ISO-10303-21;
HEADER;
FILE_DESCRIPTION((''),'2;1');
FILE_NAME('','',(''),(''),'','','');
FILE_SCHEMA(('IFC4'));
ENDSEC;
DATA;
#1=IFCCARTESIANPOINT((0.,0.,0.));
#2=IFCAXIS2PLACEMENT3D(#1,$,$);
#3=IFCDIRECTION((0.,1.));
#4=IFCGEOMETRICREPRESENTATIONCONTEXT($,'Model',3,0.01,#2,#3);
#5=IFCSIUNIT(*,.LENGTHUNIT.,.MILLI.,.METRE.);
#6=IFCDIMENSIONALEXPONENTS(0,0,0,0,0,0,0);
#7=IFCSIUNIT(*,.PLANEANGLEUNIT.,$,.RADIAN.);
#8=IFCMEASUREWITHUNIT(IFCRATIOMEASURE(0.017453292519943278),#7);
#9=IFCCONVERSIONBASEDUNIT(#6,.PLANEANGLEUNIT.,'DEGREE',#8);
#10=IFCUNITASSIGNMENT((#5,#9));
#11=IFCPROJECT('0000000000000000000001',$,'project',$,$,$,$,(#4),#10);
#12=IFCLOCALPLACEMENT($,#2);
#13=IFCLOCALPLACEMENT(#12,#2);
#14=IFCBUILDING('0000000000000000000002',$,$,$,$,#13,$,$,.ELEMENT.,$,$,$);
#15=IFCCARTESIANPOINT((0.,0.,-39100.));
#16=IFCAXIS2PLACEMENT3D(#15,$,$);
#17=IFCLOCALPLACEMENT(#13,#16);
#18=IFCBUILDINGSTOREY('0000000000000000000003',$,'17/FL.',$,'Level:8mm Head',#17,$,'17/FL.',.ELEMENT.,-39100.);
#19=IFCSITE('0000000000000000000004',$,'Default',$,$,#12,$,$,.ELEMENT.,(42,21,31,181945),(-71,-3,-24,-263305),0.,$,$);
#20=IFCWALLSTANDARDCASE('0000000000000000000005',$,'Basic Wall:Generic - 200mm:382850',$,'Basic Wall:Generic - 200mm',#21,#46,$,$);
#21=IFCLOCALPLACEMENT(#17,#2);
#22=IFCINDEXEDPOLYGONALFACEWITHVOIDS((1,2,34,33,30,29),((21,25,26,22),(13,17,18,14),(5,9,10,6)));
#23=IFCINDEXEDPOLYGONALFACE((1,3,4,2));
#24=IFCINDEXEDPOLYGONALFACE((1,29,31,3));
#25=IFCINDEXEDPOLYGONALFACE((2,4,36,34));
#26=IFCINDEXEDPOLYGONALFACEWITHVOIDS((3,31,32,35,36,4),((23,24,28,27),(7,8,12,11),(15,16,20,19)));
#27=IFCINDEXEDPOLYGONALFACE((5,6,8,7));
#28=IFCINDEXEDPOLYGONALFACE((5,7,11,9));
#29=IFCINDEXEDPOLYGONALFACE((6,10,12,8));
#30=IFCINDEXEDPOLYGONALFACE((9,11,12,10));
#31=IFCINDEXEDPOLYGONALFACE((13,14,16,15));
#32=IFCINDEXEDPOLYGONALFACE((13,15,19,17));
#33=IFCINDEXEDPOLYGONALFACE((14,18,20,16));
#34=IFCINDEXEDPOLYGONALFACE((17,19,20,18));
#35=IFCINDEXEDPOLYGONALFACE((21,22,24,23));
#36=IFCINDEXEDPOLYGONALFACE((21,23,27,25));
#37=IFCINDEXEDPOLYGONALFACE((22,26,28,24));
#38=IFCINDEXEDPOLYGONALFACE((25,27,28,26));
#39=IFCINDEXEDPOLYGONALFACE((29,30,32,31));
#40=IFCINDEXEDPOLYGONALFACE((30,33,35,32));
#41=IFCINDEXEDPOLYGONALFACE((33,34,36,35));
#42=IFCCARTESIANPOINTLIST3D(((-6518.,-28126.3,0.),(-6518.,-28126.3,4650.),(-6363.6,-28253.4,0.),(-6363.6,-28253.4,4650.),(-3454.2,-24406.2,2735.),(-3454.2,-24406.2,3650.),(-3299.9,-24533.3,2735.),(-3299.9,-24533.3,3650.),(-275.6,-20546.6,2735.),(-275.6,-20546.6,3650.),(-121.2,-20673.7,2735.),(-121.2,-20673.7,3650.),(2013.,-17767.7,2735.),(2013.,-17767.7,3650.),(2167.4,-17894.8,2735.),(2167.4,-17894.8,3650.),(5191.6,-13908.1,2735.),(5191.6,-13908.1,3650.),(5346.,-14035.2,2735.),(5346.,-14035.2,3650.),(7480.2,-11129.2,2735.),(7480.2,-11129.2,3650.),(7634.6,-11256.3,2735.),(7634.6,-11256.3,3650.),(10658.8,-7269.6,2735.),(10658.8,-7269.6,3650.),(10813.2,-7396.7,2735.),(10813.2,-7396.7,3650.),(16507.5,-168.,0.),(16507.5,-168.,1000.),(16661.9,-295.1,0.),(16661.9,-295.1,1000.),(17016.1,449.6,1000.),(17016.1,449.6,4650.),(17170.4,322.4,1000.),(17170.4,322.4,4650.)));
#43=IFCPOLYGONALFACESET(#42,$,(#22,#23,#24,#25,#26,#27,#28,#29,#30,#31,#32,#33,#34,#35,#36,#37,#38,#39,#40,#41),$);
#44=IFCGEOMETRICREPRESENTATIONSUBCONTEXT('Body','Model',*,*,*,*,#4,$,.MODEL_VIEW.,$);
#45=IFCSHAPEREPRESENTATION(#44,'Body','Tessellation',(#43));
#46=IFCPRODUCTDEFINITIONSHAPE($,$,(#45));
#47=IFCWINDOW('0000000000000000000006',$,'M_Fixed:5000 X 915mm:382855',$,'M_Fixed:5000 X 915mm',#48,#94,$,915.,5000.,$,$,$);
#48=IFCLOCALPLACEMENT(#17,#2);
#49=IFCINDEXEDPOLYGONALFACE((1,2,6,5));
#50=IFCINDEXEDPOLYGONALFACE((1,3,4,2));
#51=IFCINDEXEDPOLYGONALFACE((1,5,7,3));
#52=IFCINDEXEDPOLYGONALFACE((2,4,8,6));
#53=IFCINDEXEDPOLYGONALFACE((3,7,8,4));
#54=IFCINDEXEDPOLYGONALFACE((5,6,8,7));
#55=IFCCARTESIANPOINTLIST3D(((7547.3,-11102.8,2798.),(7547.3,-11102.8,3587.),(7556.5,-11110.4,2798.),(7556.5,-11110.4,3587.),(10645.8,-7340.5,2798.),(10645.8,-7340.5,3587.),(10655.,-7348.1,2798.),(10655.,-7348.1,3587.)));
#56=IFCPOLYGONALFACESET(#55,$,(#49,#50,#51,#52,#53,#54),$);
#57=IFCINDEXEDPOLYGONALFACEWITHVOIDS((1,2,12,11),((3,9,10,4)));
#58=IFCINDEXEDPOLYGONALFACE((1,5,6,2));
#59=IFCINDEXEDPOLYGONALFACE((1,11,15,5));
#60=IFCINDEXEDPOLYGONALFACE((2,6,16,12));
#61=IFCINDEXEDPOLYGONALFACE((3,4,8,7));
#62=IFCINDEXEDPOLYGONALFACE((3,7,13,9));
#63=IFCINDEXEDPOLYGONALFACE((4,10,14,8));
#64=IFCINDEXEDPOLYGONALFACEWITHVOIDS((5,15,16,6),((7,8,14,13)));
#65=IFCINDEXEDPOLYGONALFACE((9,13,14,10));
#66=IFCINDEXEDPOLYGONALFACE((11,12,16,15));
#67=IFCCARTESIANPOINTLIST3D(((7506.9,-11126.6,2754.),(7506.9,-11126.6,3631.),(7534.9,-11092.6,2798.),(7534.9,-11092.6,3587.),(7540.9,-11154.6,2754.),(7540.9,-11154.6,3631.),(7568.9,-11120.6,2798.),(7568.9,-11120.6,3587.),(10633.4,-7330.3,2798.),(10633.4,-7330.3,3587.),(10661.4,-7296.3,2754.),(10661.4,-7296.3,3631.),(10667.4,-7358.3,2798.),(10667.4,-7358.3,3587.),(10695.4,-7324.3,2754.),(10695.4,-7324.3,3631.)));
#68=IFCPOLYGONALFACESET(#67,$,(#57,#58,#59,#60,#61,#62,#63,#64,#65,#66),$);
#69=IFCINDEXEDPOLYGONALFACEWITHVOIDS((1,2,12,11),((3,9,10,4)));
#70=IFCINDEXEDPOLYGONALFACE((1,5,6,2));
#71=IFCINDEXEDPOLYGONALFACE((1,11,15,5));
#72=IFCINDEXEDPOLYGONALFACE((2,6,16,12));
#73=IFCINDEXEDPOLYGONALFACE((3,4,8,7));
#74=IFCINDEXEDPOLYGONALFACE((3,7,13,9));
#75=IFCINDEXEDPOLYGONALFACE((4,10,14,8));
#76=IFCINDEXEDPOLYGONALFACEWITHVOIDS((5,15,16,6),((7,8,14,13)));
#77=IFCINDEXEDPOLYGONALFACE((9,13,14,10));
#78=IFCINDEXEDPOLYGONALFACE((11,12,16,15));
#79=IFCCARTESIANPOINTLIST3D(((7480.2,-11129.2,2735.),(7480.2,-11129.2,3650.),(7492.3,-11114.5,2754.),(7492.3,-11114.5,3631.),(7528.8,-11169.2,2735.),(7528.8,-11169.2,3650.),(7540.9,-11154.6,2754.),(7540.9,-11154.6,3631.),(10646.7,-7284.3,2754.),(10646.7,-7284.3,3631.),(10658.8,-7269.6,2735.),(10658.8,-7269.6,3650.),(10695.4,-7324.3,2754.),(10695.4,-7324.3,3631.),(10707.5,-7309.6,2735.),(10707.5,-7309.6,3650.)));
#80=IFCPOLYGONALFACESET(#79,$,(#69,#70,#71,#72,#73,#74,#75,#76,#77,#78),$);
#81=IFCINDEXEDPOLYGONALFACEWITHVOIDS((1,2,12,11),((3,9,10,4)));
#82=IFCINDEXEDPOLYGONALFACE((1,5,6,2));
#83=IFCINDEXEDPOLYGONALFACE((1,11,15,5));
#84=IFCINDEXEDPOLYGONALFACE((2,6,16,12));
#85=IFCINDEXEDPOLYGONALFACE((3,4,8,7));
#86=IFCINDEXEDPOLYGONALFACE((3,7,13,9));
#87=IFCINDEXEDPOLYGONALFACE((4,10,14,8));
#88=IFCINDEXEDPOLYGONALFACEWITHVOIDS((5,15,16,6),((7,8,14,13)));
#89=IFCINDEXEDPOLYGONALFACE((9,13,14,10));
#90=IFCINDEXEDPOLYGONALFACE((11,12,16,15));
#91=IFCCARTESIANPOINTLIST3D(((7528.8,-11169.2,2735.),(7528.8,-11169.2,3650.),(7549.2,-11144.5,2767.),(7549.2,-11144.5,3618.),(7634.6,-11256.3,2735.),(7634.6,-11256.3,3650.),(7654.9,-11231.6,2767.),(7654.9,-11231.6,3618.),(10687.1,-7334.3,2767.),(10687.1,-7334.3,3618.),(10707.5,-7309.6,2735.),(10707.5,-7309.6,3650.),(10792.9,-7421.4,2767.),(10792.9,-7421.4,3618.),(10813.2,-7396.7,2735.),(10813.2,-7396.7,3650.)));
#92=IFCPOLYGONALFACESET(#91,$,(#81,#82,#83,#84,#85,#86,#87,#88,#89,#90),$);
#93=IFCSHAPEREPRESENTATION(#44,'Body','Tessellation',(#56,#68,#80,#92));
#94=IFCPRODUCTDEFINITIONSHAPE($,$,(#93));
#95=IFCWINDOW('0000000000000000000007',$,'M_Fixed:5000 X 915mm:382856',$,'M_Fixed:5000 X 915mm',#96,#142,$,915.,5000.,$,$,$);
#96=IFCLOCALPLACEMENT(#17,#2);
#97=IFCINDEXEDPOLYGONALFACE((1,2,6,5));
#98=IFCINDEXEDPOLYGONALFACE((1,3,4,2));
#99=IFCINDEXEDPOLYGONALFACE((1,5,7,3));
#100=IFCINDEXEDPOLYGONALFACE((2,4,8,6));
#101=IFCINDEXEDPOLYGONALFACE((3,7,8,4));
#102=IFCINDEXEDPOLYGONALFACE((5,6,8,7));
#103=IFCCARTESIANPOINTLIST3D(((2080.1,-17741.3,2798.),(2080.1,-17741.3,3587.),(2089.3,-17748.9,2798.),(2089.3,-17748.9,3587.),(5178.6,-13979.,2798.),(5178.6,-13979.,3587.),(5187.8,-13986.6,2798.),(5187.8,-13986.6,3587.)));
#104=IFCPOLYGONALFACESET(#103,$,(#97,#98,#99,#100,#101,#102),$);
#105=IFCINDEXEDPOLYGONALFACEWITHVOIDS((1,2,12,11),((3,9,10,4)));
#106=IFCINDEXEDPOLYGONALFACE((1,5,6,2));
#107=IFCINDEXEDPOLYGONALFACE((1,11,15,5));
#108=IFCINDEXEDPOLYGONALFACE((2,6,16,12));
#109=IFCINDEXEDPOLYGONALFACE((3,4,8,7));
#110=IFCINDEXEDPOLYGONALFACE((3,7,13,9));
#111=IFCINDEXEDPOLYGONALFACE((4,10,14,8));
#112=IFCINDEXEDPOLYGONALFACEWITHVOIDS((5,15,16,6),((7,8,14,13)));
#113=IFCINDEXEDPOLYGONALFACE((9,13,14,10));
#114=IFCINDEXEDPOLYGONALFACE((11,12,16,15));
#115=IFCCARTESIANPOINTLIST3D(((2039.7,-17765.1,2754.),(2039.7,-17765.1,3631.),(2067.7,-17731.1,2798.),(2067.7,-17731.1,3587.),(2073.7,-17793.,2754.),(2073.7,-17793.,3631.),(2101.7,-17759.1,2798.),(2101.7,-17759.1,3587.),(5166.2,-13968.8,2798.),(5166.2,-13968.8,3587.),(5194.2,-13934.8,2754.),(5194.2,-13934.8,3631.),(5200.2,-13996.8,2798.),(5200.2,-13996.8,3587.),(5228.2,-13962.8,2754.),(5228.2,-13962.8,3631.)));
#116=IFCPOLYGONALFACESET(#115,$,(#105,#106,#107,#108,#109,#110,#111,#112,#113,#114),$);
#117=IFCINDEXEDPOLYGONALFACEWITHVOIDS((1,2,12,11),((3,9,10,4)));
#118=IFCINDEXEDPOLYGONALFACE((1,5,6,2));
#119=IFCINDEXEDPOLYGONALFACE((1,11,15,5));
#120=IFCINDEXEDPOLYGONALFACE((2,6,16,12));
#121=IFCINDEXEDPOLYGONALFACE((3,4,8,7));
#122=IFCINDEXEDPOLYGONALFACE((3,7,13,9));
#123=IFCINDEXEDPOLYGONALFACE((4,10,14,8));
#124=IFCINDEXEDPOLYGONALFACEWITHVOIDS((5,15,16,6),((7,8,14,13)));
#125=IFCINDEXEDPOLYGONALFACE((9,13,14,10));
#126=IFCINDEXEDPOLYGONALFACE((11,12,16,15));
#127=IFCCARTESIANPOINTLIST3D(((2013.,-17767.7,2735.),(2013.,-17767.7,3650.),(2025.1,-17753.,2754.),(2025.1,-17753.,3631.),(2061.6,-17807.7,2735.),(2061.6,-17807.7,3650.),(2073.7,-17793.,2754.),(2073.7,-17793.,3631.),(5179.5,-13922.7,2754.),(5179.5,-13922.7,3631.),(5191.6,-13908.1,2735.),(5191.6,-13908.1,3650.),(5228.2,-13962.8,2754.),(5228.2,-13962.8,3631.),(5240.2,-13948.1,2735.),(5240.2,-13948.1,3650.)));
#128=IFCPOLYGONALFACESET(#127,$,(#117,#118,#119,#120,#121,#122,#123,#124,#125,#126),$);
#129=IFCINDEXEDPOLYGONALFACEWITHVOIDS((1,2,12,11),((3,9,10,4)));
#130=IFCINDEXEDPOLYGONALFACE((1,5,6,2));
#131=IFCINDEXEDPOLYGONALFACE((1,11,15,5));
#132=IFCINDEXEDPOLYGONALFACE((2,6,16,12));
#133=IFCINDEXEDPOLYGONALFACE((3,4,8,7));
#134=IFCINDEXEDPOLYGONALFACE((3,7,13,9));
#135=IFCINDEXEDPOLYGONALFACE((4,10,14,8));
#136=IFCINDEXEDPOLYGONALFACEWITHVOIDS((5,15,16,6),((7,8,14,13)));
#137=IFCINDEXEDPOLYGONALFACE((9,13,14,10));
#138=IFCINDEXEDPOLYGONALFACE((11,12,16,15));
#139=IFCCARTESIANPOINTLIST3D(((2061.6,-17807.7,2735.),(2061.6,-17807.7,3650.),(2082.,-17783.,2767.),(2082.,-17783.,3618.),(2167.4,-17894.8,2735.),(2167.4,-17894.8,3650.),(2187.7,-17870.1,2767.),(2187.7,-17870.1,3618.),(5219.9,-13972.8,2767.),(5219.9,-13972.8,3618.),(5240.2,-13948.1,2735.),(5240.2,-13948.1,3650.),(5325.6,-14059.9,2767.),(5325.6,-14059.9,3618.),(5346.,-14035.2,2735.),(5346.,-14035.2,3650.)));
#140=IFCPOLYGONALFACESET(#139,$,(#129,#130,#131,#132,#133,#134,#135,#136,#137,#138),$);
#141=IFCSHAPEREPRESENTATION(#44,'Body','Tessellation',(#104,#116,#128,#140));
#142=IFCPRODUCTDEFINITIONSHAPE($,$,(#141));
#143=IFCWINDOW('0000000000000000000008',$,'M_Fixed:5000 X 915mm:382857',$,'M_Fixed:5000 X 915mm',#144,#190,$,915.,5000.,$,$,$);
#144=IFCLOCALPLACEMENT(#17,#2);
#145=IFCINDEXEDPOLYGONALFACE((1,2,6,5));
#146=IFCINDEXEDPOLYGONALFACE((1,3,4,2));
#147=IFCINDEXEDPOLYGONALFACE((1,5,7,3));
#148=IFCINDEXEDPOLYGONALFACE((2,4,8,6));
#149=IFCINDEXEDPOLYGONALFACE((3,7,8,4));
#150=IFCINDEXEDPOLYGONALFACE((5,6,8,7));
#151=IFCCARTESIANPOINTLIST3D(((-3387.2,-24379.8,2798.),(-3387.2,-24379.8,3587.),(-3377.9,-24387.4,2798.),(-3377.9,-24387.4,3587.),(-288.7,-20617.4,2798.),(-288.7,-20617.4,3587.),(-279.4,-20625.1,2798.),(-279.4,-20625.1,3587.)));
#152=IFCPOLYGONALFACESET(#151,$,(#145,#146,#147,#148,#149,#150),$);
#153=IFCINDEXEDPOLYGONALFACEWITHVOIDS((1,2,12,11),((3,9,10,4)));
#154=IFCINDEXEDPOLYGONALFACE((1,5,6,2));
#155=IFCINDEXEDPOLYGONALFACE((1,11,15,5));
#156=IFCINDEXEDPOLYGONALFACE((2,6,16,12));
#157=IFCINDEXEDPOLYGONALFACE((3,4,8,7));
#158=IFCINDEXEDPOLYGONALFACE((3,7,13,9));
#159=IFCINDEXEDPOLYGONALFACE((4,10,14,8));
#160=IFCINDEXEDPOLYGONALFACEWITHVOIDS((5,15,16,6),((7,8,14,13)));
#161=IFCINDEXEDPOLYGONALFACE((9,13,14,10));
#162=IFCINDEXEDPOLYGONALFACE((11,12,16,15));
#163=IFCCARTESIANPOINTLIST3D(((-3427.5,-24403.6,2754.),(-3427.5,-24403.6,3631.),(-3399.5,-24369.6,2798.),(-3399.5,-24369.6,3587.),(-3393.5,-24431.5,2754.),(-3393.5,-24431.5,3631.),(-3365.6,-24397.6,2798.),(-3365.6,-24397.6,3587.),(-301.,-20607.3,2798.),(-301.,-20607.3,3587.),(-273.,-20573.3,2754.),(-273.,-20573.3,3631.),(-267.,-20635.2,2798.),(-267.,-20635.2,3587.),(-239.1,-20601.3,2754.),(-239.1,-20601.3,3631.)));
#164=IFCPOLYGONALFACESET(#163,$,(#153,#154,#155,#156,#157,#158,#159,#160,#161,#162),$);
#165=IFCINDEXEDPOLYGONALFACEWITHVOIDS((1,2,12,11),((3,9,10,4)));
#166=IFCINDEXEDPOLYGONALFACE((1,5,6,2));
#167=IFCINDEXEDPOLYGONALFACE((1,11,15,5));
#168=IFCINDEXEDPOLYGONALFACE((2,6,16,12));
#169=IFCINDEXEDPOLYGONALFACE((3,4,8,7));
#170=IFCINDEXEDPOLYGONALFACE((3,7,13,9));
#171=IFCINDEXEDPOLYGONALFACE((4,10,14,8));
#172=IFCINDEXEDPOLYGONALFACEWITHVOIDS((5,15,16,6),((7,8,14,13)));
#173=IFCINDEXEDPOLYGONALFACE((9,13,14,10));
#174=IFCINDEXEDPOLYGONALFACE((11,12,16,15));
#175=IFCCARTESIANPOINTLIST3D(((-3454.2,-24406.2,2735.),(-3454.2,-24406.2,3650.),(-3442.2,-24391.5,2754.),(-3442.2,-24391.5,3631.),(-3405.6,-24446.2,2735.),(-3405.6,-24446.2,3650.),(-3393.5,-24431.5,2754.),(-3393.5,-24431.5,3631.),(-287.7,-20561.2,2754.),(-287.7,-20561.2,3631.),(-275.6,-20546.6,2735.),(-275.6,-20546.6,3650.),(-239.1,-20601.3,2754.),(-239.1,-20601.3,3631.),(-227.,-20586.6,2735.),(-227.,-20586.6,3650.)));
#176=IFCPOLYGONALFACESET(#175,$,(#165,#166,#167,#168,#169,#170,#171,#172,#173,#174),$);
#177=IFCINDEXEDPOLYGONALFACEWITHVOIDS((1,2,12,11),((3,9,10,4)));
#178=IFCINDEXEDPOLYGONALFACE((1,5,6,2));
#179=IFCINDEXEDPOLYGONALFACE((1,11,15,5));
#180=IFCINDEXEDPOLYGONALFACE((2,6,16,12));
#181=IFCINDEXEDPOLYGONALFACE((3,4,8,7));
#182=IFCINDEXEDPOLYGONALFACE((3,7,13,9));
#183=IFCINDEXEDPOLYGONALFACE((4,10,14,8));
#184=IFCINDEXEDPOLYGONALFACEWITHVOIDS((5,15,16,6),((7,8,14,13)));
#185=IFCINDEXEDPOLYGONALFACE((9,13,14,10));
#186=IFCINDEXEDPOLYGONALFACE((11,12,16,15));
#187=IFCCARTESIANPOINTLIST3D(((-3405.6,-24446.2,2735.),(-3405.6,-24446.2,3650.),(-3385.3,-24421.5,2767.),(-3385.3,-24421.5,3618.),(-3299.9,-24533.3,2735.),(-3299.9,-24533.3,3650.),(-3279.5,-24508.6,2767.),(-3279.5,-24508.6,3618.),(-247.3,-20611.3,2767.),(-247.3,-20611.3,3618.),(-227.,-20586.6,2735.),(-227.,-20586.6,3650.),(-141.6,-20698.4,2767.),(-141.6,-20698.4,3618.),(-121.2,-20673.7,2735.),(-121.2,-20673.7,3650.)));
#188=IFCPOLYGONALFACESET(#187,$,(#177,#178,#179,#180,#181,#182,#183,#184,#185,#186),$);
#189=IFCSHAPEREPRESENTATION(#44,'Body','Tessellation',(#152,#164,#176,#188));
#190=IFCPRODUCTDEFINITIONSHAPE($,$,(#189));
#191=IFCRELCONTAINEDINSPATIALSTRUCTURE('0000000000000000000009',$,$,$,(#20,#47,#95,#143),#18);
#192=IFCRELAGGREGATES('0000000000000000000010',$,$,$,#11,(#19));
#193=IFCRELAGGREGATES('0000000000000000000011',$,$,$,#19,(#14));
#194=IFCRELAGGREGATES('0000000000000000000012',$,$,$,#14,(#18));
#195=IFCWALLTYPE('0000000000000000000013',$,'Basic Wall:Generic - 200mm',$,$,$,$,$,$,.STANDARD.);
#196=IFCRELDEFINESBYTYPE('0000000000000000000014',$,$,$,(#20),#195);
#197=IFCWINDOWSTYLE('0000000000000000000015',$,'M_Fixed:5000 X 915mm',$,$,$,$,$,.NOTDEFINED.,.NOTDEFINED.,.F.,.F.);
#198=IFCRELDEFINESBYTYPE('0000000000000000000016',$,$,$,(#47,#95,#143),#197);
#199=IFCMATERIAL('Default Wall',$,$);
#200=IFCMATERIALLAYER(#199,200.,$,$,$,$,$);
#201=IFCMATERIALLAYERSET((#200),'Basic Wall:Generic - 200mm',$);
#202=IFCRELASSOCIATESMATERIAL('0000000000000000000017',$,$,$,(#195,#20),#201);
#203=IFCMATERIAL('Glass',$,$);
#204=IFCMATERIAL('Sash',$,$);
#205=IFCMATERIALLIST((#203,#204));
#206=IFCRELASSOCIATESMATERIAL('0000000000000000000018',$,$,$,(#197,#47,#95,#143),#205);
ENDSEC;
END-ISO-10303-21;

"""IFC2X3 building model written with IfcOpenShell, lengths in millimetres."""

from ifc_helpers import new_model, entity, si_unit, converted_unit, direction, frame, frame_2d, origin, place, context, subcontext, project, spatial, polyline, rectangle, outline, extrude, source, transform, mapped, material, material_list, layer, layer_set, layer_usage, type_object, type_shapes, element, fill, save


model = new_model("IFC2X3")

# Units and contexts
model_context = context("Model", 3, precision=0.01, world=origin(), true_north=direction((0.0, 1.0)))
body_context = subcontext(model_context, "Body", "Model", "MODEL_VIEW")
ifc_project = project(units=[si_unit("LENGTHUNIT", "METRE", prefix="MILLI"), converted_unit("PLANEANGLEUNIT", "DEGREE", entity("IfcRatioMeasure", 0.017453292519943278), si_unit("PLANEANGLEUNIT", "RADIAN"), dimensions=[0, 0, 0, 0, 0, 0, 0])], contexts=[model_context])

# Site, building, storey
site_placement = place(None, origin())
site = spatial("IfcSite", under=ifc_project, at=site_placement, Name="Default", CompositionType="ELEMENT", RefLatitude=(42, 21, 31, 181945), RefLongitude=(-71, -3, -24, -263305), RefElevation=0.0)
building_placement = place(site_placement, origin())
building = spatial("IfcBuilding", under=site, at=building_placement, CompositionType="ELEMENT")
storey_placement = place(building_placement, frame((0.0, 0.0, -39100.0)))
storey = spatial("IfcBuildingStorey", under=building, at=storey_placement, Name="17/FL.", ObjectType="Level:8mm Head", LongName="17/FL.", CompositionType="ELEMENT", Elevation=-39100.0)

# Shared definitions
ifc_material_1 = material(Name="Default Wall")
ifc_layer = layer(ifc_material_1, 200.0)
ifc_layer_set = layer_set([ifc_layer], Name="Basic Wall:Generic - 200mm")
ifc_layer_usage = layer_usage(ifc_layer_set, "AXIS2", "NEGATIVE", 100.0)
wall_type = type_object("IfcWallType", Name="Basic Wall:Generic - 200mm", PredefinedType="STANDARD", material=ifc_layer_set)

# Wall, openings, windows
wall_1_placement = place(storey_placement, frame((17093.2, 386.0, 0.0), z_axis=(0.0, 0.0, 1.0), x_axis=(-0.635723, -0.771917, 0.0)))
wall_1 = element("IfcWallStandardCase", 1, at=wall_1_placement, inside=storey, type_object=wall_type, material=ifc_layer_usage, Name="Basic Wall:Generic - 200mm:382850", ObjectType="Basic Wall:Generic - 200mm", context=body_context, shape_type="SweptSolid", body=[
    extrude(rectangle(XDim=37019.3, YDim=200.0, at=frame_2d((18509.7, 0.0), x_axis=(-1.0, 0.0))), origin(), (0.0, 0.0, 1.0), 4650.0),
])
opening_1_placement = place(wall_1_placement, origin())
element("IfcOpeningElement", 2, at=opening_1_placement, cuts=wall_1, ObjectType="Opening", context=body_context, shape_type="SweptSolid", body=[
    extrude(rectangle(XDim=1000.0, YDim=1012.7, at=frame_2d((0.0, 0.0), x_axis=(1.0, 0.0))), frame((293.7, -183.3, 500.0), z_axis=(0.0, 1.0, 0.0), x_axis=(0.0, 0.0, -1.0)), (0.0, 0.0, 1.0), 1010.1),
])
opening_2_placement = place(wall_1_placement, frame((15000.0, 100.0, 2735.0)))
opening_2 = element("IfcOpeningElement", 3, at=opening_2_placement, cuts=wall_1, ObjectType="Opening", context=body_context, shape_type="SweptSolid", body=[
    extrude(rectangle(XDim=915.0, YDim=5000.0, at=frame_2d((457.5, 2500.0), x_axis=(1.0, 0.0))), frame((0.0, 0.0, 0.0), z_axis=(0.0, -1.0, 0.0), x_axis=(0.0, 0.0, 1.0)), (0.0, 0.0, 1.0), 200.0),
])
opening_3_placement = place(wall_1_placement, frame((23600.0, 100.0, 2735.0)))
opening_3 = element("IfcOpeningElement", 4, at=opening_3_placement, cuts=wall_1, ObjectType="Opening", context=body_context, shape_type="SweptSolid", body=[
    extrude(rectangle(XDim=915.0, YDim=5000.0, at=frame_2d((457.5, 2500.0), x_axis=(1.0, 0.0))), frame((0.0, 0.0, 0.0), z_axis=(0.0, -1.0, 0.0), x_axis=(0.0, 0.0, 1.0)), (0.0, 0.0, 1.0), 200.0),
])
opening_4_placement = place(wall_1_placement, frame((32200.0, 100.0, 2735.0)))
opening_4 = element("IfcOpeningElement", 5, at=opening_4_placement, cuts=wall_1, ObjectType="Opening", context=body_context, shape_type="SweptSolid", body=[
    extrude(rectangle(XDim=915.0, YDim=5000.0, at=frame_2d((457.5, 2500.0), x_axis=(1.0, 0.0))), frame((0.0, 0.0, 0.0), z_axis=(0.0, -1.0, 0.0), x_axis=(0.0, 0.0, 1.0)), (0.0, 0.0, 1.0), 200.0),
])
ifc_material_2 = material(Name="Glass")
ifc_material_3 = material(Name="Sash")
ifc_material_list = material_list([ifc_material_2, ifc_material_3])
window_style_1 = type_object("IfcWindowStyle", Name="M_Fixed:5000 X 915mm", ConstructionType="NOTDEFINED", OperationType="NOTDEFINED", ParameterTakesPrecedence=False, Sizeable=False, material=ifc_material_list)
shared_shape_1 = source(origin(), body_context, "Body", "SweptSolid", [
    extrude(rectangle(XDim=12.0, YDim=4874.0, at=frame_2d((0.0, 0.0), x_axis=(1.0, 0.0))), frame((2500.0, 159.0, 63.0), z_axis=(0.0, 0.0, 1.0), x_axis=(0.0, -1.0, 0.0)), (0.0, 0.0, 1.0), 789.0),
    extrude(outline(polyline([(-2481.0, -438.5), (2481.0, -438.5), (2481.0, 438.5), (-2481.0, 438.5), (-2481.0, -438.5)]), holes=[polyline([(-2437.0, -394.5), (-2437.0, 394.5), (2437.0, 394.5), (2437.0, -394.5), (-2437.0, -394.5)])]), frame((2500.0, 137.0, 457.5), z_axis=(0.0, 1.0, 0.0), x_axis=(1.0, 0.0, 0.0)), (0.0, 0.0, 1.0), 44.0),
    extrude(outline(polyline([(-2500.0, -457.5), (2500.0, -457.5), (2500.0, 457.5), (-2500.0, 457.5), (-2500.0, -457.5)]), holes=[polyline([(-2481.0, -438.5), (-2481.0, 438.5), (2481.0, 438.5), (2481.0, -438.5), (-2481.0, -438.5)])]), frame((2500.0, 137.0, 457.5), z_axis=(0.0, 1.0, 0.0), x_axis=(1.0, 0.0, 0.0)), (0.0, 0.0, 1.0), 63.0),
    extrude(outline(polyline([(-2500.0, -457.5), (2500.0, -457.5), (2500.0, 457.5), (-2500.0, 457.5), (-2500.0, -457.5)]), holes=[polyline([(-2468.0, -425.5), (-2468.0, 425.5), (2468.0, 425.5), (2468.0, -425.5), (-2468.0, -425.5)])]), frame((2500.0, 0.0, 457.5), z_axis=(0.0, 1.0, 0.0), x_axis=(1.0, 0.0, 0.0)), (0.0, 0.0, 1.0), 137.0),
])
type_shapes(window_style_1, [shared_shape_1])
window_1_placement = place(opening_2_placement, frame((0.0, 0.0, 0.0), z_axis=(0.0, 0.0, 1.0), x_axis=(-1.0, 0.0, 0.0)))
window_1 = element("IfcWindow", 6, at=window_1_placement, inside=storey, type_object=window_style_1, material=ifc_material_list, Name="M_Fixed:5000 X 915mm:382855", ObjectType="M_Fixed:5000 X 915mm", OverallHeight=915.0, OverallWidth=5000.0, context=body_context, shape_type="MappedRepresentation", body=[
    mapped(shared_shape_1, transform((0.0, 0.0, 0.0), scale=1.0)),
])
fill(opening_2, window_1)
window_2_placement = place(opening_3_placement, frame((0.0, 0.0, 0.0), z_axis=(0.0, 0.0, 1.0), x_axis=(-1.0, 0.0, 0.0)))
window_2 = element("IfcWindow", 7, at=window_2_placement, inside=storey, type_object=window_style_1, material=ifc_material_list, Name="M_Fixed:5000 X 915mm:382856", ObjectType="M_Fixed:5000 X 915mm", OverallHeight=915.0, OverallWidth=5000.0, context=body_context, shape_type="MappedRepresentation", body=[
    mapped(shared_shape_1, transform((0.0, 0.0, 0.0), scale=1.0)),
])
fill(opening_3, window_2)
window_3_placement = place(opening_4_placement, frame((0.0, 0.0, 0.0), z_axis=(0.0, 0.0, 1.0), x_axis=(-1.0, 0.0, 0.0)))
window_3 = element("IfcWindow", 8, at=window_3_placement, inside=storey, type_object=window_style_1, material=ifc_material_list, Name="M_Fixed:5000 X 915mm:382857", ObjectType="M_Fixed:5000 X 915mm", OverallHeight=915.0, OverallWidth=5000.0, context=body_context, shape_type="MappedRepresentation", body=[
    mapped(shared_shape_1, transform((0.0, 0.0, 0.0), scale=1.0)),
])
fill(opening_4, window_3)

save(model, "model.ifc")
